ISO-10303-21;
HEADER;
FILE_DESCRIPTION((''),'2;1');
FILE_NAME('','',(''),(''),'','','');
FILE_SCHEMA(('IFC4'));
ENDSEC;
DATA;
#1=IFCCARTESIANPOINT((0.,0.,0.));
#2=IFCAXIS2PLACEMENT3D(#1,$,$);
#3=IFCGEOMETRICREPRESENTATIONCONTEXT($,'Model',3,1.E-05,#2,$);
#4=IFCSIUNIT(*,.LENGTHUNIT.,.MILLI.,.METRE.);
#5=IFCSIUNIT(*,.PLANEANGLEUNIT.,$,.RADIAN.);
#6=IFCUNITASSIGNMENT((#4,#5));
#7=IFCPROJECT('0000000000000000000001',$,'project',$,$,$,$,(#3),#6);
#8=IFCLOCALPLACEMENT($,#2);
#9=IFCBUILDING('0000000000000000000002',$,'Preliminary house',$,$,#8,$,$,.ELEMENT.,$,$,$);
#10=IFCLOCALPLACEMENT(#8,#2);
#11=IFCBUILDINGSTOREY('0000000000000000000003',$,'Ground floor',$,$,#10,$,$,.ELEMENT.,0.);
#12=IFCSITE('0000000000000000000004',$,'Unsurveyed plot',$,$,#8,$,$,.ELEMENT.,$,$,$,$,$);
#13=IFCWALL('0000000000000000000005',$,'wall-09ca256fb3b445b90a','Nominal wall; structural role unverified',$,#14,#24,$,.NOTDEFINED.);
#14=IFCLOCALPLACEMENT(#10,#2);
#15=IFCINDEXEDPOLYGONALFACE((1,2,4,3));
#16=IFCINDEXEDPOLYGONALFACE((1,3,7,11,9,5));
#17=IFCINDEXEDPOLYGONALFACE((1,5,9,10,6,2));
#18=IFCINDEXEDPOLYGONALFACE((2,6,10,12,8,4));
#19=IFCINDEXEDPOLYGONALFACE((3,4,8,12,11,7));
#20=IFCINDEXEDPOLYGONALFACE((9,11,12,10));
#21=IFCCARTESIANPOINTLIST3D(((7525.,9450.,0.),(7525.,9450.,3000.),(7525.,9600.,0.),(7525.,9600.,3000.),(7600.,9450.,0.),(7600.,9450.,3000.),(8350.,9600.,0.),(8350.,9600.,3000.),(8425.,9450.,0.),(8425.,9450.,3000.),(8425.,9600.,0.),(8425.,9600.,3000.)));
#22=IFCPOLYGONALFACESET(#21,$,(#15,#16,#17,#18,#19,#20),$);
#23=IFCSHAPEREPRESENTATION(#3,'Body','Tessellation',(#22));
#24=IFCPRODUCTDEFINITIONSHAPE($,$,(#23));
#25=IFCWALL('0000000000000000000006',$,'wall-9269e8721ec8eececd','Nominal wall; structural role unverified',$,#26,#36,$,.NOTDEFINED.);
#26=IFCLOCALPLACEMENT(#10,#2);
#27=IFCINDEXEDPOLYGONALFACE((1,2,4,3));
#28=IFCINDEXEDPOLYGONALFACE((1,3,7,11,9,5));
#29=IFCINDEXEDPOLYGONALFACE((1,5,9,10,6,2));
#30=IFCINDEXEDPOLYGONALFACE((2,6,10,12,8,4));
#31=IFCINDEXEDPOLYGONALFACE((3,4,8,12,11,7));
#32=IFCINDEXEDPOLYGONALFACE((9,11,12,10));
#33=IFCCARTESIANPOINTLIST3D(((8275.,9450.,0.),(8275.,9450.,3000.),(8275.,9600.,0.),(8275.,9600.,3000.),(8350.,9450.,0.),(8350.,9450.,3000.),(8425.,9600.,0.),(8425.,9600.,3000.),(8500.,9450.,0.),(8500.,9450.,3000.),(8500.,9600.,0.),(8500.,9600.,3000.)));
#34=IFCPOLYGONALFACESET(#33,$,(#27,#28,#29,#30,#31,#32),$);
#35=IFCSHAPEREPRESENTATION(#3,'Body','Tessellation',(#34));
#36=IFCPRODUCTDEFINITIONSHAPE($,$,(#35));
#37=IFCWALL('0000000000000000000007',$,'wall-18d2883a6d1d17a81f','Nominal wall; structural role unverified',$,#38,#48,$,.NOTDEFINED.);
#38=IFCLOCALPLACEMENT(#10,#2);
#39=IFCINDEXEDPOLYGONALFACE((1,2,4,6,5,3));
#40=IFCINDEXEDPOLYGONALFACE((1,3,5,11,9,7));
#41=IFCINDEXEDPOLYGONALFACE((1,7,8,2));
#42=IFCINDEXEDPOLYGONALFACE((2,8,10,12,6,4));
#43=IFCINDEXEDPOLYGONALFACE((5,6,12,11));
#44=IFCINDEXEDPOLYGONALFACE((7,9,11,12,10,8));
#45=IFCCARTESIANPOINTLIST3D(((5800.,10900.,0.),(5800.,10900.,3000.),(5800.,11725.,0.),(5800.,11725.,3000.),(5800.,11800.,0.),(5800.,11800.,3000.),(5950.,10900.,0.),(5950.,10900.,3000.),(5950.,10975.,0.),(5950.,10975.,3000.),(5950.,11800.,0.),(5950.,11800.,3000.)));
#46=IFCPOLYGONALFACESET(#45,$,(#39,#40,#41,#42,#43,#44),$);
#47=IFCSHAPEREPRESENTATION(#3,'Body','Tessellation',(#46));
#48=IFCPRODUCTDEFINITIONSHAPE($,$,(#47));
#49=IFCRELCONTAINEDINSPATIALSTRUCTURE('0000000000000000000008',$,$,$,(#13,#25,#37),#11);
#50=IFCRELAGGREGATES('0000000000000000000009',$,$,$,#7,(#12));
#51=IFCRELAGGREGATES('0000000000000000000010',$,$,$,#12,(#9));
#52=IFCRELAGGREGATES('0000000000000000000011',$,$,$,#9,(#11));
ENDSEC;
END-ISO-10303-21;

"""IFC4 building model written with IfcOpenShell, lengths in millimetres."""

from ifc_helpers import new_model, si_unit, origin, place, context, project, spatial, polyline, outline, extrude, element, save


model = new_model("IFC4")

# Units and contexts
model_context = context("Model", 3, precision=1e-05, world=origin())
ifc_project = project(units=[si_unit("LENGTHUNIT", "METRE", prefix="MILLI"), si_unit("PLANEANGLEUNIT", "RADIAN")], contexts=[model_context])

# Site, building, storey
placement_1 = place(None, origin())
site = spatial("IfcSite", under=ifc_project, at=placement_1, Name="Unsurveyed plot", CompositionType="ELEMENT")
building = spatial("IfcBuilding", under=site, at=placement_1, Name="Preliminary house", CompositionType="ELEMENT")
placement_2 = place(placement_1, origin())
storey = spatial("IfcBuildingStorey", under=building, at=placement_2, Name="Ground floor", CompositionType="ELEMENT", Elevation=0.0)

# Walls
element("IfcWall", 1, at=placement_2, inside=storey, Name="wall-09ca256fb3b445b90a", Description="Nominal wall; structural role unverified", PredefinedType="NOTDEFINED", context=model_context, shape_type="SweptSolid", body=[
    extrude(outline(polyline([(8350.0, 9600.0), (8425.0, 9600.0), (8425.0, 9450.0), (7600.0, 9450.0), (7525.0, 9450.0), (7525.0, 9600.0), (8350.0, 9600.0)])), origin(), (0.0, 0.0, 1.0), 3000.0),
])
element("IfcWall", 2, at=placement_2, inside=storey, Name="wall-9269e8721ec8eececd", Description="Nominal wall; structural role unverified", PredefinedType="NOTDEFINED", context=model_context, shape_type="SweptSolid", body=[
    extrude(outline(polyline([(8425.0, 9600.0), (8500.0, 9600.0), (8500.0, 9450.0), (8350.0, 9450.0), (8275.0, 9450.0), (8275.0, 9600.0), (8425.0, 9600.0)])), origin(), (0.0, 0.0, 1.0), 3000.0),
])
element("IfcWall", 3, at=placement_2, inside=storey, Name="wall-18d2883a6d1d17a81f", Description="Nominal wall; structural role unverified", PredefinedType="NOTDEFINED", context=model_context, shape_type="SweptSolid", body=[
    extrude(outline(polyline([(5800.0, 11725.0), (5800.0, 11800.0), (5950.0, 11800.0), (5950.0, 10975.0), (5950.0, 10900.0), (5800.0, 10900.0), (5800.0, 11725.0)])), origin(), (0.0, 0.0, 1.0), 3000.0),
])

save(model, "model.ifc")
